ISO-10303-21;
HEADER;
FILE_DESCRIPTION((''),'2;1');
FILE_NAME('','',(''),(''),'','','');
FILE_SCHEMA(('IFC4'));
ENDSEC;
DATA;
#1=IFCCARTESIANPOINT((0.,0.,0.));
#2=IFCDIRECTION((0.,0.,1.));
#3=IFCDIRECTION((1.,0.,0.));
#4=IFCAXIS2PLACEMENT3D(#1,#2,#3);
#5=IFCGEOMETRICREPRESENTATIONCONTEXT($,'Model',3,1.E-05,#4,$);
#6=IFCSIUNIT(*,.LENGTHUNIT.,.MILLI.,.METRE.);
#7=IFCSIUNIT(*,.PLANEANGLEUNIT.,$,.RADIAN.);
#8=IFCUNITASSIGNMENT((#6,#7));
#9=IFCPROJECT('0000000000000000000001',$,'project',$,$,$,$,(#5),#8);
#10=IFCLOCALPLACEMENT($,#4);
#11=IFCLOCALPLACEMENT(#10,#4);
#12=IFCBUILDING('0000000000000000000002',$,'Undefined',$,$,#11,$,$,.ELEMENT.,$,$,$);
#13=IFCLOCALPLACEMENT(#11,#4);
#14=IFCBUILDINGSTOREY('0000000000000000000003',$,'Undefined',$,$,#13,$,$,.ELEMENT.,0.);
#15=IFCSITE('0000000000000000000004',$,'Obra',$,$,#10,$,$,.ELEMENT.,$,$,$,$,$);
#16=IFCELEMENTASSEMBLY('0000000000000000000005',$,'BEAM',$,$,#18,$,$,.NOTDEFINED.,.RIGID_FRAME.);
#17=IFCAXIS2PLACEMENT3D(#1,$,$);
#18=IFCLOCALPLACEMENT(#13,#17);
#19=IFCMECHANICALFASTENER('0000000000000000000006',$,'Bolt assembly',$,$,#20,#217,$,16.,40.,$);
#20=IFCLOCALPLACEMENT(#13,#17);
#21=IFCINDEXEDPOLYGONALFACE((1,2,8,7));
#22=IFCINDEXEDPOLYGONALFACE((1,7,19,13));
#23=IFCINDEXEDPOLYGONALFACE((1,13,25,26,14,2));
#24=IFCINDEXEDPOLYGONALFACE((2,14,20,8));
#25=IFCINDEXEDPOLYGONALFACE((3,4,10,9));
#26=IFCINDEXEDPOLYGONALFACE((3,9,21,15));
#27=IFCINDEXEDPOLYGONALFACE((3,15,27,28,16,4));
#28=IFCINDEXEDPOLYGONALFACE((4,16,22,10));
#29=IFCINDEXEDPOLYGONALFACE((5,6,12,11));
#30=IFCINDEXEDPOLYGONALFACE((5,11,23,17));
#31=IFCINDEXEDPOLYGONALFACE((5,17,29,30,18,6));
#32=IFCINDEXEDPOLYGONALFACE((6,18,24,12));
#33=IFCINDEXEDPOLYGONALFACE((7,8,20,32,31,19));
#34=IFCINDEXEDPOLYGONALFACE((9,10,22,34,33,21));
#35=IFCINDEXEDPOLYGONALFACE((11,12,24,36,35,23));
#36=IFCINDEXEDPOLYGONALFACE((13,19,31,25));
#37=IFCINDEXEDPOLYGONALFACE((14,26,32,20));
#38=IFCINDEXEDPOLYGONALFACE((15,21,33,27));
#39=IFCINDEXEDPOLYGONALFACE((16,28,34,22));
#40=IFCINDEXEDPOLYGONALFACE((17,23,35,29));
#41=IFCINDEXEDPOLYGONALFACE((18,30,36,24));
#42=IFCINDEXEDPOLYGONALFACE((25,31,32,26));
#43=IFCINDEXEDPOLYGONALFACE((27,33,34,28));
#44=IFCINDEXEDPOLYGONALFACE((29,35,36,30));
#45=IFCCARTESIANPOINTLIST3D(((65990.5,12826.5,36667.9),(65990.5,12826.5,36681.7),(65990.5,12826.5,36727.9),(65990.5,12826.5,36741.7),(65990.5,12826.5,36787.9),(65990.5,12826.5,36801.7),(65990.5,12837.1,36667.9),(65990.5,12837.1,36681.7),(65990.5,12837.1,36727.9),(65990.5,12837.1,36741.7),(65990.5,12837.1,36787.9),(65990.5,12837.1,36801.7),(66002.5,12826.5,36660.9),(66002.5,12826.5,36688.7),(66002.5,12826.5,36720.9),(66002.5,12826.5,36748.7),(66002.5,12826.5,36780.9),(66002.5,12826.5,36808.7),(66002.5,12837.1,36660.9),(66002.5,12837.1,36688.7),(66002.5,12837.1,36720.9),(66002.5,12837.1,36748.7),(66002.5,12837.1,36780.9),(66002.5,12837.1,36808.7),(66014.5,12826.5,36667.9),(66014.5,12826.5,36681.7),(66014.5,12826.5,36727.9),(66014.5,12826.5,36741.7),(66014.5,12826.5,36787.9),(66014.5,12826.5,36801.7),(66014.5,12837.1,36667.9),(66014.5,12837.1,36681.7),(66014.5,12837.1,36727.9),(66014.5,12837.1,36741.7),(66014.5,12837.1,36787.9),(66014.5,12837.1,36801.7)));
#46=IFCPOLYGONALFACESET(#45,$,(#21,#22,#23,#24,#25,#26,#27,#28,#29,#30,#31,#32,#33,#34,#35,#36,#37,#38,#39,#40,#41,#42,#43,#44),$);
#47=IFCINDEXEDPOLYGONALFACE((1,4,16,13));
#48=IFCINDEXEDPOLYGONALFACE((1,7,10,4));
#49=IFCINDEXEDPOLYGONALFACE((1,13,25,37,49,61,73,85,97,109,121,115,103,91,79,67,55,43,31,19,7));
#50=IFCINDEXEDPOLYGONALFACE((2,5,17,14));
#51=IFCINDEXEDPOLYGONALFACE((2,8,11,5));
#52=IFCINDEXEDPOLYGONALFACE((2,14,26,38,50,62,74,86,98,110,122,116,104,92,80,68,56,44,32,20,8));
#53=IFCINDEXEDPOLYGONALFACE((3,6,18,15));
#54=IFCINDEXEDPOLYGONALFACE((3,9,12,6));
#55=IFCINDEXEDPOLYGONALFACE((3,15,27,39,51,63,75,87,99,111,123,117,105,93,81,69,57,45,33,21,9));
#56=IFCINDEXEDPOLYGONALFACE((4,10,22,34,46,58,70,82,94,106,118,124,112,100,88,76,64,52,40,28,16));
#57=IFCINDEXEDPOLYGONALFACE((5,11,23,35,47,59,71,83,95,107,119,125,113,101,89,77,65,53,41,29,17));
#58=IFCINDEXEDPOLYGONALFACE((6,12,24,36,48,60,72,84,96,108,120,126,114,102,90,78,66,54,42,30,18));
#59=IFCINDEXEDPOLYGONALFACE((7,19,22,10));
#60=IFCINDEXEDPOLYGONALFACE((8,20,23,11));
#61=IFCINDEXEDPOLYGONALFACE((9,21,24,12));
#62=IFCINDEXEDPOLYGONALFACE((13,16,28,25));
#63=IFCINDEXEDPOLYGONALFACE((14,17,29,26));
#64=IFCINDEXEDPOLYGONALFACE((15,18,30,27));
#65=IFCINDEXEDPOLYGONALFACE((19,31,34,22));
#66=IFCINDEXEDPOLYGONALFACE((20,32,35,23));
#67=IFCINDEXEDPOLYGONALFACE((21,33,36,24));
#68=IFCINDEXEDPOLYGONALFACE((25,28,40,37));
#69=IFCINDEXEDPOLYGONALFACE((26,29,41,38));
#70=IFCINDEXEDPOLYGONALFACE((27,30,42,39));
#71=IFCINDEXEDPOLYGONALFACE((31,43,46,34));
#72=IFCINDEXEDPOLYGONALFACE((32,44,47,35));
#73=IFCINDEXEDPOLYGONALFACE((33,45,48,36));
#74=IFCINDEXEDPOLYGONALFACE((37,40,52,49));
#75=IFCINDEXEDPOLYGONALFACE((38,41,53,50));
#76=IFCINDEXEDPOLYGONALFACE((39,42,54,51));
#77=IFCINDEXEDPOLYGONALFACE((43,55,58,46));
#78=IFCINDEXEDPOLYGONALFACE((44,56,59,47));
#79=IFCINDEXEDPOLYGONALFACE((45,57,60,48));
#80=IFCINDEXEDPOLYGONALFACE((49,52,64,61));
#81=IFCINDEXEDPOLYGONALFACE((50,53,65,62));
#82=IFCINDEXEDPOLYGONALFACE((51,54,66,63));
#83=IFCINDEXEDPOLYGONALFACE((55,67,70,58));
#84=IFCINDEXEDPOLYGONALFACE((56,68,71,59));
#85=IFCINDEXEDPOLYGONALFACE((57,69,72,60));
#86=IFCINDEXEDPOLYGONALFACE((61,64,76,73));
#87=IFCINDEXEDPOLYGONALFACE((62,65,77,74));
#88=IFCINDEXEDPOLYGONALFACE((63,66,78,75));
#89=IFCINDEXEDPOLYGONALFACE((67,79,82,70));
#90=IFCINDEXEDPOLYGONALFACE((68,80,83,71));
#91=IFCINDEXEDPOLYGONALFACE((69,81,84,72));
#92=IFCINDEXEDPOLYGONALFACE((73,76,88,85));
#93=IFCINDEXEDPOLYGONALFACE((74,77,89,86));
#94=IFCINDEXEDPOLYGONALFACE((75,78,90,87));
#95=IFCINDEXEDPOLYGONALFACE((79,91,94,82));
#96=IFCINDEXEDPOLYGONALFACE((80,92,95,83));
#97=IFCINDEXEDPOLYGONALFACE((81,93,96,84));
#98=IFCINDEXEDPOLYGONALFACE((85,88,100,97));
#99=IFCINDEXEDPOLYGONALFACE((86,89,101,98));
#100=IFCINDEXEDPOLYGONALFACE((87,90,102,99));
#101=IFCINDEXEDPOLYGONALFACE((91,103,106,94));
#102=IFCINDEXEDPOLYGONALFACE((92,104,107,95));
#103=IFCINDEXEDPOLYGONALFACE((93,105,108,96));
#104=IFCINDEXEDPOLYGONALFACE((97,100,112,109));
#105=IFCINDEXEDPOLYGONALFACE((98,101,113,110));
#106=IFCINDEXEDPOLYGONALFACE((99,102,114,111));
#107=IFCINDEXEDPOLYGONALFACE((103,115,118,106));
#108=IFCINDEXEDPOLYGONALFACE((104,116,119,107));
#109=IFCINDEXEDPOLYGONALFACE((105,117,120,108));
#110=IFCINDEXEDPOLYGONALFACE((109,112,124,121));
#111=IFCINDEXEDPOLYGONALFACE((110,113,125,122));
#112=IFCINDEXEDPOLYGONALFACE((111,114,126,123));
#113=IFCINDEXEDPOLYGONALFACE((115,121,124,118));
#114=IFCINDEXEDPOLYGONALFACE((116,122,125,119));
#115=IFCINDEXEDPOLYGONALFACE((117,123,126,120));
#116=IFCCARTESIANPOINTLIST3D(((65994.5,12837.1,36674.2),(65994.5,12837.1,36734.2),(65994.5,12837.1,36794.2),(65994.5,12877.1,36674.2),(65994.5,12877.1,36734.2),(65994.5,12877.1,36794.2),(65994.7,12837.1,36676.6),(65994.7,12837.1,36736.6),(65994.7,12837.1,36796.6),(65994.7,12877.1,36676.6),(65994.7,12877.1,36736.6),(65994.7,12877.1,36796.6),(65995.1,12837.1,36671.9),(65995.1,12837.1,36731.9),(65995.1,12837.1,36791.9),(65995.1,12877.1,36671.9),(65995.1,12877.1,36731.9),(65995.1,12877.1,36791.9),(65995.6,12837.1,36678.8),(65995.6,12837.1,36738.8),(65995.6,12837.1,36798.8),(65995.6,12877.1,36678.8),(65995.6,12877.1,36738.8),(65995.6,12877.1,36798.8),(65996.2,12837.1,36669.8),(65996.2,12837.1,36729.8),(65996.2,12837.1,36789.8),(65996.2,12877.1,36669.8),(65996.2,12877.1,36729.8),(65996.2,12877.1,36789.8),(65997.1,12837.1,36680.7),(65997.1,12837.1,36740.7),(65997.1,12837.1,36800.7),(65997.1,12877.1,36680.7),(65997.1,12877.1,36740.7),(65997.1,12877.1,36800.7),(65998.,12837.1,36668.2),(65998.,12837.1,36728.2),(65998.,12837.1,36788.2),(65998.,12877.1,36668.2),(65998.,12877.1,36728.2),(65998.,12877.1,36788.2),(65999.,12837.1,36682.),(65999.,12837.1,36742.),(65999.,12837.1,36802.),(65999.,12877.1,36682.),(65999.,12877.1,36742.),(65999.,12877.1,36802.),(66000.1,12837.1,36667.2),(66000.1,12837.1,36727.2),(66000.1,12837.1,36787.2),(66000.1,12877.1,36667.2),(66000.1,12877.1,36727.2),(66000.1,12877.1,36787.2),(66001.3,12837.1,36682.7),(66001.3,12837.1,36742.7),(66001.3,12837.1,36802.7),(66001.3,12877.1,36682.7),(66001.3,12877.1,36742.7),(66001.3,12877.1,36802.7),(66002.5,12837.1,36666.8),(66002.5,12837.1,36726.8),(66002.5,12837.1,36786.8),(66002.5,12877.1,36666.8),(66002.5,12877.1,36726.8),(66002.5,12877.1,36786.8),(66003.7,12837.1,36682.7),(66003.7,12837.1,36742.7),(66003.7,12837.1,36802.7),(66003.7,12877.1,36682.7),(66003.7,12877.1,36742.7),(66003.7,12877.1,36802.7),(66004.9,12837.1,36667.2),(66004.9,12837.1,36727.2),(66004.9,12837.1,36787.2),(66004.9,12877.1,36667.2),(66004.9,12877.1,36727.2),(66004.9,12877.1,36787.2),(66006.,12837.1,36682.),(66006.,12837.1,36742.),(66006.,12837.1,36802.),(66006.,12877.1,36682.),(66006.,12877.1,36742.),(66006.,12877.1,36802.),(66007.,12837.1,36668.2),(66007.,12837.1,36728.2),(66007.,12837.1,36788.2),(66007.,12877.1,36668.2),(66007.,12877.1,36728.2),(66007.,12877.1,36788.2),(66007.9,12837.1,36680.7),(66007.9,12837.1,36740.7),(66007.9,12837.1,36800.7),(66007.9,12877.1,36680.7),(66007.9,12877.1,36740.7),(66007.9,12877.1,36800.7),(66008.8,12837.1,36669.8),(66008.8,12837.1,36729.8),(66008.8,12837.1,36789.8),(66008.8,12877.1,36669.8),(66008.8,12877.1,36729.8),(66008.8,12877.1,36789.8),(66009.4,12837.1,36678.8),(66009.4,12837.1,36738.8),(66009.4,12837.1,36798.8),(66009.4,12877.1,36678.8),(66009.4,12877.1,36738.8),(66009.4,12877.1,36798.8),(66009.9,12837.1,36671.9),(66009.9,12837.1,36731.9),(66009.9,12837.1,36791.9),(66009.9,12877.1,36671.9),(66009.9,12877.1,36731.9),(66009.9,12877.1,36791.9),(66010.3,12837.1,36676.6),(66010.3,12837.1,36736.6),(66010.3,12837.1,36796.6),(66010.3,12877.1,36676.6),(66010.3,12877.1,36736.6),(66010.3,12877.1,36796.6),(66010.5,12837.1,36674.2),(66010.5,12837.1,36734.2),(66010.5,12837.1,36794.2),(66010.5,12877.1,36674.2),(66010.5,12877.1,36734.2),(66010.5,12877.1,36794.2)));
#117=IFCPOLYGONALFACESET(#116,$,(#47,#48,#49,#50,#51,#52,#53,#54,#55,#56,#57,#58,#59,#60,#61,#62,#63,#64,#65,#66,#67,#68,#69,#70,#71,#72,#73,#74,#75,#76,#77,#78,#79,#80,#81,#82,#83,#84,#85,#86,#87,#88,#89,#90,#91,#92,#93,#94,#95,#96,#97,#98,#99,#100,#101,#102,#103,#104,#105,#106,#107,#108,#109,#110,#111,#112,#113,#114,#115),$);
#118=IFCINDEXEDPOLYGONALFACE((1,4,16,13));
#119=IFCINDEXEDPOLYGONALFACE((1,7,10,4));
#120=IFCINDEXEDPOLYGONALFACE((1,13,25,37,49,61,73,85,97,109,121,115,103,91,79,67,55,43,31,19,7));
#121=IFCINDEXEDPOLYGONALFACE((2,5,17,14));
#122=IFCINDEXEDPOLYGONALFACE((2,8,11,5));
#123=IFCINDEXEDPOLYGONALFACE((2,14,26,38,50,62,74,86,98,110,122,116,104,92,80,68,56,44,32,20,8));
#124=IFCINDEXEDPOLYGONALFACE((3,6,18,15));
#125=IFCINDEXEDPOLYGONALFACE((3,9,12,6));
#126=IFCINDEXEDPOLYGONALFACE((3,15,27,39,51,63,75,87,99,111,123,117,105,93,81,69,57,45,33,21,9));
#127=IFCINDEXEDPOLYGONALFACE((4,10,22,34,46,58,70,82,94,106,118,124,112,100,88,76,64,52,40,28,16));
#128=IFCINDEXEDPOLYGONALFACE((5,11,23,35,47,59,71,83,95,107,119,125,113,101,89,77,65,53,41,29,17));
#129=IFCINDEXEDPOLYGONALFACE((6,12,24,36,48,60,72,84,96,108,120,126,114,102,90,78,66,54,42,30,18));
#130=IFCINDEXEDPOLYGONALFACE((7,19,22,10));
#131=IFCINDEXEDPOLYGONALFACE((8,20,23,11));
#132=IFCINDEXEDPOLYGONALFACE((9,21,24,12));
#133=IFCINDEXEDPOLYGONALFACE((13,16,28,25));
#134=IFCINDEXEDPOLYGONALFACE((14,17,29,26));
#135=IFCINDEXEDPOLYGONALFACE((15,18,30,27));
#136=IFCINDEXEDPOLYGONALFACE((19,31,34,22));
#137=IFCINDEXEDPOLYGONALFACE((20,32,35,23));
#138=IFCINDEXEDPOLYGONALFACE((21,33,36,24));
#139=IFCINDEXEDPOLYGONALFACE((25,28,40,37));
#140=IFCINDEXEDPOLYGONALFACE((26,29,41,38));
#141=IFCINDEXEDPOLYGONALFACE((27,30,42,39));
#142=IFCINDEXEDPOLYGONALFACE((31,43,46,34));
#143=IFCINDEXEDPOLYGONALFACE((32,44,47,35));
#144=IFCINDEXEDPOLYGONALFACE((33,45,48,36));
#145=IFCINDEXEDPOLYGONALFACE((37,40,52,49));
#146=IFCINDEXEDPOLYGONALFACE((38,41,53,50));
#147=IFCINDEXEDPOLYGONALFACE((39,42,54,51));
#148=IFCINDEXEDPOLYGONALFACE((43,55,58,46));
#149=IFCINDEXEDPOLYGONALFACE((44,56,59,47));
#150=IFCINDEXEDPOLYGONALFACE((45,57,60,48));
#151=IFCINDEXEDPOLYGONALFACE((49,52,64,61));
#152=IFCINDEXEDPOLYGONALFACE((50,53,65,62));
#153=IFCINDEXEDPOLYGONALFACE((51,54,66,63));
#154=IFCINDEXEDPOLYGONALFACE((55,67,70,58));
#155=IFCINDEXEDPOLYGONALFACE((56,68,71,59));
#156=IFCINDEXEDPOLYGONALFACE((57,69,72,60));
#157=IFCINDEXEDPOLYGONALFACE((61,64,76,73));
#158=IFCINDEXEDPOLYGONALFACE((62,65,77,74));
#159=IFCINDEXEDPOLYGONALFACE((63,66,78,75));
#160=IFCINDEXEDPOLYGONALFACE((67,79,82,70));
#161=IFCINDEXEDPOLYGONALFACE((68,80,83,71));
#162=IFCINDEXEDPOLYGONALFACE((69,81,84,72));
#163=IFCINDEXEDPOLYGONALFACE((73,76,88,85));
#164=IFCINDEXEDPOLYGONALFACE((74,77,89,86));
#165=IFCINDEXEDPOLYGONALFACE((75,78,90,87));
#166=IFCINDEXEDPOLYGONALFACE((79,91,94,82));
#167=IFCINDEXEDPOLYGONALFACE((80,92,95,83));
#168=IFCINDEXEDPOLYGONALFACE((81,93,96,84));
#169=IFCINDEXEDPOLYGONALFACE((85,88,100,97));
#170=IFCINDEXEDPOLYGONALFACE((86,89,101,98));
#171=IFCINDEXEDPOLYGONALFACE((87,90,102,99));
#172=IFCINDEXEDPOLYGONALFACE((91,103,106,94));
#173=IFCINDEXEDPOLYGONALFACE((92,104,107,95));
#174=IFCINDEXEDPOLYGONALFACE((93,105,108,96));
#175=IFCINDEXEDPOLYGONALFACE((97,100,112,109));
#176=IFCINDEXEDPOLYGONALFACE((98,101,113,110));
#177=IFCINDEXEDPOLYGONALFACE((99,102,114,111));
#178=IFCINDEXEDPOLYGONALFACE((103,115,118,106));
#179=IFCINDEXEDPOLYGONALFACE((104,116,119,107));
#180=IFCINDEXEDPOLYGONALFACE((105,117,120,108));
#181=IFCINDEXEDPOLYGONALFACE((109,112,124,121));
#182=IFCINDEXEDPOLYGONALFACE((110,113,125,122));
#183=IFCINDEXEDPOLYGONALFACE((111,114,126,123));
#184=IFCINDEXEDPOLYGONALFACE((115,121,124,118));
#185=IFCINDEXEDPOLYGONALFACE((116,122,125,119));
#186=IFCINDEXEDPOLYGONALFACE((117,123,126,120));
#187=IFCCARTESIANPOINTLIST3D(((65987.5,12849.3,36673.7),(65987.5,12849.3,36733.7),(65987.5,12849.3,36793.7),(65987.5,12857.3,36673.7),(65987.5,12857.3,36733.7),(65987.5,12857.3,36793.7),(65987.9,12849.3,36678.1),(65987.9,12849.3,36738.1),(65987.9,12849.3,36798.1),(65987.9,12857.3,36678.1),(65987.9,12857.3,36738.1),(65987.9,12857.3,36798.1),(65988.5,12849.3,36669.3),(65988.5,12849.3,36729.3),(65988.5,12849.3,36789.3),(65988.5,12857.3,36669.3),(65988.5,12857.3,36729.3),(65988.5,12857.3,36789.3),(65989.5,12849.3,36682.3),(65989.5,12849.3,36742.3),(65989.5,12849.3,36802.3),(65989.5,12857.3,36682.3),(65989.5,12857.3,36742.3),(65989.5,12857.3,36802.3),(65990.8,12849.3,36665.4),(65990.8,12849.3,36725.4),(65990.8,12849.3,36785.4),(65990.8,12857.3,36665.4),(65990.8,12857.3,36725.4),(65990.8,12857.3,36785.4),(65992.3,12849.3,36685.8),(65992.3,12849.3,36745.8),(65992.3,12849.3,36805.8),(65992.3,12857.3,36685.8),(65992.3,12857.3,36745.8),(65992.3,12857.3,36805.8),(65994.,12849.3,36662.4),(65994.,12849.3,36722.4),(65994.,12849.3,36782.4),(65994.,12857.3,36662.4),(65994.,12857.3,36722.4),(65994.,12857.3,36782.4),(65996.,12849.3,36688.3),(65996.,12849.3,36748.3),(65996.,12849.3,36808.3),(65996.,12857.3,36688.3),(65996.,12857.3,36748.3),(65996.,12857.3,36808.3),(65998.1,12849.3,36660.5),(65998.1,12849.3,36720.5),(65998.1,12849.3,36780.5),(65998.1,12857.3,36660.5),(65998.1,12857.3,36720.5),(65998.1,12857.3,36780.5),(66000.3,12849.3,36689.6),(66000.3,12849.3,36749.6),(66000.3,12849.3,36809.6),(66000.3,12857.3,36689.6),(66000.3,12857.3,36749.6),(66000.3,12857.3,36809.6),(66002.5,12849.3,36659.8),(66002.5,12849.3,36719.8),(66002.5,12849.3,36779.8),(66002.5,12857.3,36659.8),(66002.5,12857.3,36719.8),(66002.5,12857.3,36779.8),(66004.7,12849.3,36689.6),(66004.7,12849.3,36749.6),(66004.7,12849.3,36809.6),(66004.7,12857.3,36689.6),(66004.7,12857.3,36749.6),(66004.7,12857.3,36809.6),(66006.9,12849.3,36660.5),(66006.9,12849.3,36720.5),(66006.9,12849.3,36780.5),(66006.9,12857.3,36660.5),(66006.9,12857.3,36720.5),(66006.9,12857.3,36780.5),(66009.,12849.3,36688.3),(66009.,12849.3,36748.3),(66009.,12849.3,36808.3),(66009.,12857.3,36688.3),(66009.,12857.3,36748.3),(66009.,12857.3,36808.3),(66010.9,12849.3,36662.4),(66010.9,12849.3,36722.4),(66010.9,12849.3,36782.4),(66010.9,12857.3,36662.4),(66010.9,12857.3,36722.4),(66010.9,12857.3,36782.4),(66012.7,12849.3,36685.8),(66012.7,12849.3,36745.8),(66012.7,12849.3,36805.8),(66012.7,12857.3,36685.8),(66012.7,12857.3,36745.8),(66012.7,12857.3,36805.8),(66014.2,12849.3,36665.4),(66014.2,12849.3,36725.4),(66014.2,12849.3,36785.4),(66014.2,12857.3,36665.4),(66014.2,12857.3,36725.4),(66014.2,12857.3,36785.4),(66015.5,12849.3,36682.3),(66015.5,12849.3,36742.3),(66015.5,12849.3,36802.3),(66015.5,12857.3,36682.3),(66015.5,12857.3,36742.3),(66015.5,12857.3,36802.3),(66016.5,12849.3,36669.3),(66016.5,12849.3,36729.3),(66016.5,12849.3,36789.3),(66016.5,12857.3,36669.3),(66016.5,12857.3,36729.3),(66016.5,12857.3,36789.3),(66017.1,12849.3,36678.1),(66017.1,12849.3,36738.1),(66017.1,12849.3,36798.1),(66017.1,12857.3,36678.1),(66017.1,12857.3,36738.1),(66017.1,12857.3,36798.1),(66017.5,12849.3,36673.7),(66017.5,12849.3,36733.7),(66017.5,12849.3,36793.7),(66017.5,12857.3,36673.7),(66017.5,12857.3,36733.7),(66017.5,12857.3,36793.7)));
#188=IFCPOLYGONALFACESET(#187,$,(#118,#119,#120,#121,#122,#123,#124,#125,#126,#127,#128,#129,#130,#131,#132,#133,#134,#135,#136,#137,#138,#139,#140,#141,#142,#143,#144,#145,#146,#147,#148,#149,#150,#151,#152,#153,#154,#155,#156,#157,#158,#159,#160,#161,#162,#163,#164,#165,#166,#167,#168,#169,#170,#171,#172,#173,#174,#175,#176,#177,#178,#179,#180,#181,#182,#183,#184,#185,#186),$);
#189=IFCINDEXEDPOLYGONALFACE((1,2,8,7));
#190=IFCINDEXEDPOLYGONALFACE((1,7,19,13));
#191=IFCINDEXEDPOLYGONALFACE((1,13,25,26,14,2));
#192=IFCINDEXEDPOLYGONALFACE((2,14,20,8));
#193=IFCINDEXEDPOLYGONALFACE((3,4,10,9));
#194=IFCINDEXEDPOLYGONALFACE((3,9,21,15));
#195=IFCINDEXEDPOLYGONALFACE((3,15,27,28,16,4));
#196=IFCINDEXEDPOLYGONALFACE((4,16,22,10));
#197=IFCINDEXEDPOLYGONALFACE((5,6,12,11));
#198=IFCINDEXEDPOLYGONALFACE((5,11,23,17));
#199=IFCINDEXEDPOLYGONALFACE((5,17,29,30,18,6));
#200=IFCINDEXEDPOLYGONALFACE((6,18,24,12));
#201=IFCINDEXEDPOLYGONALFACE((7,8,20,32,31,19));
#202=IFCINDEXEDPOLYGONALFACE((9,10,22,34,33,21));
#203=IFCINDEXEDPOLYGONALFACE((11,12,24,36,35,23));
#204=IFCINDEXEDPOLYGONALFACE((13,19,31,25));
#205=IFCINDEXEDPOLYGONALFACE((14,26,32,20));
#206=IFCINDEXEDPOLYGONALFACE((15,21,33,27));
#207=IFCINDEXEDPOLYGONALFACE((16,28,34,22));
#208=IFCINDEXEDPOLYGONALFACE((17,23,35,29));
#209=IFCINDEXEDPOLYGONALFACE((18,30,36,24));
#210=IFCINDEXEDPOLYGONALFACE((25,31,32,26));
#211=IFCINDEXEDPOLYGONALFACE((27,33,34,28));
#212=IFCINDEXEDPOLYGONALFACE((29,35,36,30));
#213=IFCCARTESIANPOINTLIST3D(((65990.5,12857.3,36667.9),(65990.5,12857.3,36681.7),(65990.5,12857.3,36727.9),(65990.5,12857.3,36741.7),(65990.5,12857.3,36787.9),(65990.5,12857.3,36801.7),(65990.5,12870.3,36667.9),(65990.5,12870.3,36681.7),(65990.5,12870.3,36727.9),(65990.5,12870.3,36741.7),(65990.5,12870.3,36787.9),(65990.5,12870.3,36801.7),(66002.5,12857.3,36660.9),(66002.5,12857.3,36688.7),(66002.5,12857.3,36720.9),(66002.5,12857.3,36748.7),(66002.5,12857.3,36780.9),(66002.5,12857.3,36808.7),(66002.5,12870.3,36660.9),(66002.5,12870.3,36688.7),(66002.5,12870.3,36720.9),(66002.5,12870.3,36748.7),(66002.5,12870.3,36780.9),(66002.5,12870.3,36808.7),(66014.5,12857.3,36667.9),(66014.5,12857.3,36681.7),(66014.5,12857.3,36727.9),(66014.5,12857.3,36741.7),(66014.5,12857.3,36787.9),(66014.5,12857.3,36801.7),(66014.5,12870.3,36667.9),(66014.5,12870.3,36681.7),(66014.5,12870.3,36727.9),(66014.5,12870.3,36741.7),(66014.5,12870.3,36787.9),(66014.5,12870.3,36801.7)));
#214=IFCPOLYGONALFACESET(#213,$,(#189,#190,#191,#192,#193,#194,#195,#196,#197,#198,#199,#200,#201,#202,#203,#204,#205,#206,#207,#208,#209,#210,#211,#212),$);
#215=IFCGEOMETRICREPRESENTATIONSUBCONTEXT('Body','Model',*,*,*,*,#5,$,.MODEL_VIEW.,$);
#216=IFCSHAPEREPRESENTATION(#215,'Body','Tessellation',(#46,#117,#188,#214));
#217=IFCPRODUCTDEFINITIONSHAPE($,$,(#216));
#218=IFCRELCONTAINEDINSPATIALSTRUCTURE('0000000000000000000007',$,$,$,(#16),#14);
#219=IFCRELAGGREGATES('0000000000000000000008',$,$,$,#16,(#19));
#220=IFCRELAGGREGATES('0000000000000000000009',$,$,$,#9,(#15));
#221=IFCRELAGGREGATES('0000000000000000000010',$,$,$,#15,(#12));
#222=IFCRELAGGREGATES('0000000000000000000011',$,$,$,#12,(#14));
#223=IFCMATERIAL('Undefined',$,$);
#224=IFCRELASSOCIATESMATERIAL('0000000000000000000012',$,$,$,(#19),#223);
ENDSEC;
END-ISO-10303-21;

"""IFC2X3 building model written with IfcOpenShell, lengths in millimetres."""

from ifc_helpers import new_model, si_unit, frame, origin_with_axes, origin_2d_with_axis, place, context, subcontext, project, spatial, polyline, circle, outline, extrude, source, transform, mapped, material, element, aggregate, save


model = new_model("IFC2X3")

# Units and contexts
model_context = context("Model", 3, precision=1e-05, world=origin_with_axes())
body_context = subcontext(model_context, "Body", "Model", "MODEL_VIEW")
ifc_project = project(units=[si_unit("LENGTHUNIT", "METRE", prefix="MILLI"), si_unit("PLANEANGLEUNIT", "RADIAN")], contexts=[model_context])

# Site, building, storey
site_placement = place(None, origin_with_axes())
site = spatial("IfcSite", under=ifc_project, at=site_placement, Name="Obra", CompositionType="ELEMENT")
building_placement = place(site_placement, origin_with_axes())
building = spatial("IfcBuilding", under=site, at=building_placement, Name="Undefined", CompositionType="ELEMENT")
storey_placement = place(building_placement, origin_with_axes())
storey = spatial("IfcBuildingStorey", under=building, at=storey_placement, Name="Undefined", CompositionType="ELEMENT", Elevation=0.0)

# Element assembly, mechanical fastener
ifc_material_1 = material(Name="Undefined")
assembly_1_placement = place(storey_placement, origin_with_axes())
assembly_1 = element("IfcElementAssembly", 1, at=assembly_1_placement, inside=storey, Name="BEAM", AssemblyPlace="NOTDEFINED", PredefinedType="RIGID_FRAME")
shared_shape_1 = source(origin_with_axes(), body_context, "Body", "SweptSolid", [
    extrude(outline(polyline([(13.9, 0.0), (6.9, 12.0), (-6.9, 12.0), (-13.9, 0.0), (-6.9, -12.0), (6.9, -12.0), (13.9, 0.0)])), frame((0.0, -13.7, 0.0), z_axis=(0.0, 1.0, 0.0), x_axis=(1.0, 0.0, 0.0)), (0.0, 0.0, 1.0), 10.6),
    extrude(circle(Radius=8.0, at=origin_2d_with_axis()), frame((0.0, -3.1, 0.0), z_axis=(0.0, 1.0, 0.0), x_axis=(1.0, 0.0, 0.0)), (0.0, 0.0, 1.0), 40.0),
    extrude(circle(Radius=15.0, at=origin_2d_with_axis()), frame((0.0, 9.1, 0.0), z_axis=(0.0, 1.0, 0.0), x_axis=(1.0, 0.0, 0.0)), (0.0, 0.0, 1.0), 8.0),
    extrude(outline(polyline([(13.9, 0.0), (6.9, 12.0), (-6.9, 12.0), (-13.9, 0.0), (-6.9, -12.0), (6.9, -12.0), (13.9, 0.0)])), frame((0.0, 17.1, 0.0), z_axis=(0.0, 1.0, 0.0), x_axis=(1.0, 0.0, 0.0)), (0.0, 0.0, 1.0), 13.0),
])
mechanical_fastener_1_placement = place(assembly_1_placement, frame((65952.5, 12840.2, 36829.8), z_axis=(1.0, 0.0, 0.0), x_axis=(0.0, 0.0, -1.0)))
mechanical_fastener_1 = element("IfcMechanicalFastener", 2, at=mechanical_fastener_1_placement, material=ifc_material_1, Name="Bolt assembly", NominalDiameter=16.0, NominalLength=40.0, context=body_context, shape_type="MappedRepresentation", body=[
    mapped(shared_shape_1, transform((35.0, 0.0, 50.0))),
    mapped(shared_shape_1, transform((95.0, 0.0, 50.0))),
    mapped(shared_shape_1, transform((155.0, 0.0, 50.0))),
])
aggregate(assembly_1, [mechanical_fastener_1])

save(model, "model.ifc")
